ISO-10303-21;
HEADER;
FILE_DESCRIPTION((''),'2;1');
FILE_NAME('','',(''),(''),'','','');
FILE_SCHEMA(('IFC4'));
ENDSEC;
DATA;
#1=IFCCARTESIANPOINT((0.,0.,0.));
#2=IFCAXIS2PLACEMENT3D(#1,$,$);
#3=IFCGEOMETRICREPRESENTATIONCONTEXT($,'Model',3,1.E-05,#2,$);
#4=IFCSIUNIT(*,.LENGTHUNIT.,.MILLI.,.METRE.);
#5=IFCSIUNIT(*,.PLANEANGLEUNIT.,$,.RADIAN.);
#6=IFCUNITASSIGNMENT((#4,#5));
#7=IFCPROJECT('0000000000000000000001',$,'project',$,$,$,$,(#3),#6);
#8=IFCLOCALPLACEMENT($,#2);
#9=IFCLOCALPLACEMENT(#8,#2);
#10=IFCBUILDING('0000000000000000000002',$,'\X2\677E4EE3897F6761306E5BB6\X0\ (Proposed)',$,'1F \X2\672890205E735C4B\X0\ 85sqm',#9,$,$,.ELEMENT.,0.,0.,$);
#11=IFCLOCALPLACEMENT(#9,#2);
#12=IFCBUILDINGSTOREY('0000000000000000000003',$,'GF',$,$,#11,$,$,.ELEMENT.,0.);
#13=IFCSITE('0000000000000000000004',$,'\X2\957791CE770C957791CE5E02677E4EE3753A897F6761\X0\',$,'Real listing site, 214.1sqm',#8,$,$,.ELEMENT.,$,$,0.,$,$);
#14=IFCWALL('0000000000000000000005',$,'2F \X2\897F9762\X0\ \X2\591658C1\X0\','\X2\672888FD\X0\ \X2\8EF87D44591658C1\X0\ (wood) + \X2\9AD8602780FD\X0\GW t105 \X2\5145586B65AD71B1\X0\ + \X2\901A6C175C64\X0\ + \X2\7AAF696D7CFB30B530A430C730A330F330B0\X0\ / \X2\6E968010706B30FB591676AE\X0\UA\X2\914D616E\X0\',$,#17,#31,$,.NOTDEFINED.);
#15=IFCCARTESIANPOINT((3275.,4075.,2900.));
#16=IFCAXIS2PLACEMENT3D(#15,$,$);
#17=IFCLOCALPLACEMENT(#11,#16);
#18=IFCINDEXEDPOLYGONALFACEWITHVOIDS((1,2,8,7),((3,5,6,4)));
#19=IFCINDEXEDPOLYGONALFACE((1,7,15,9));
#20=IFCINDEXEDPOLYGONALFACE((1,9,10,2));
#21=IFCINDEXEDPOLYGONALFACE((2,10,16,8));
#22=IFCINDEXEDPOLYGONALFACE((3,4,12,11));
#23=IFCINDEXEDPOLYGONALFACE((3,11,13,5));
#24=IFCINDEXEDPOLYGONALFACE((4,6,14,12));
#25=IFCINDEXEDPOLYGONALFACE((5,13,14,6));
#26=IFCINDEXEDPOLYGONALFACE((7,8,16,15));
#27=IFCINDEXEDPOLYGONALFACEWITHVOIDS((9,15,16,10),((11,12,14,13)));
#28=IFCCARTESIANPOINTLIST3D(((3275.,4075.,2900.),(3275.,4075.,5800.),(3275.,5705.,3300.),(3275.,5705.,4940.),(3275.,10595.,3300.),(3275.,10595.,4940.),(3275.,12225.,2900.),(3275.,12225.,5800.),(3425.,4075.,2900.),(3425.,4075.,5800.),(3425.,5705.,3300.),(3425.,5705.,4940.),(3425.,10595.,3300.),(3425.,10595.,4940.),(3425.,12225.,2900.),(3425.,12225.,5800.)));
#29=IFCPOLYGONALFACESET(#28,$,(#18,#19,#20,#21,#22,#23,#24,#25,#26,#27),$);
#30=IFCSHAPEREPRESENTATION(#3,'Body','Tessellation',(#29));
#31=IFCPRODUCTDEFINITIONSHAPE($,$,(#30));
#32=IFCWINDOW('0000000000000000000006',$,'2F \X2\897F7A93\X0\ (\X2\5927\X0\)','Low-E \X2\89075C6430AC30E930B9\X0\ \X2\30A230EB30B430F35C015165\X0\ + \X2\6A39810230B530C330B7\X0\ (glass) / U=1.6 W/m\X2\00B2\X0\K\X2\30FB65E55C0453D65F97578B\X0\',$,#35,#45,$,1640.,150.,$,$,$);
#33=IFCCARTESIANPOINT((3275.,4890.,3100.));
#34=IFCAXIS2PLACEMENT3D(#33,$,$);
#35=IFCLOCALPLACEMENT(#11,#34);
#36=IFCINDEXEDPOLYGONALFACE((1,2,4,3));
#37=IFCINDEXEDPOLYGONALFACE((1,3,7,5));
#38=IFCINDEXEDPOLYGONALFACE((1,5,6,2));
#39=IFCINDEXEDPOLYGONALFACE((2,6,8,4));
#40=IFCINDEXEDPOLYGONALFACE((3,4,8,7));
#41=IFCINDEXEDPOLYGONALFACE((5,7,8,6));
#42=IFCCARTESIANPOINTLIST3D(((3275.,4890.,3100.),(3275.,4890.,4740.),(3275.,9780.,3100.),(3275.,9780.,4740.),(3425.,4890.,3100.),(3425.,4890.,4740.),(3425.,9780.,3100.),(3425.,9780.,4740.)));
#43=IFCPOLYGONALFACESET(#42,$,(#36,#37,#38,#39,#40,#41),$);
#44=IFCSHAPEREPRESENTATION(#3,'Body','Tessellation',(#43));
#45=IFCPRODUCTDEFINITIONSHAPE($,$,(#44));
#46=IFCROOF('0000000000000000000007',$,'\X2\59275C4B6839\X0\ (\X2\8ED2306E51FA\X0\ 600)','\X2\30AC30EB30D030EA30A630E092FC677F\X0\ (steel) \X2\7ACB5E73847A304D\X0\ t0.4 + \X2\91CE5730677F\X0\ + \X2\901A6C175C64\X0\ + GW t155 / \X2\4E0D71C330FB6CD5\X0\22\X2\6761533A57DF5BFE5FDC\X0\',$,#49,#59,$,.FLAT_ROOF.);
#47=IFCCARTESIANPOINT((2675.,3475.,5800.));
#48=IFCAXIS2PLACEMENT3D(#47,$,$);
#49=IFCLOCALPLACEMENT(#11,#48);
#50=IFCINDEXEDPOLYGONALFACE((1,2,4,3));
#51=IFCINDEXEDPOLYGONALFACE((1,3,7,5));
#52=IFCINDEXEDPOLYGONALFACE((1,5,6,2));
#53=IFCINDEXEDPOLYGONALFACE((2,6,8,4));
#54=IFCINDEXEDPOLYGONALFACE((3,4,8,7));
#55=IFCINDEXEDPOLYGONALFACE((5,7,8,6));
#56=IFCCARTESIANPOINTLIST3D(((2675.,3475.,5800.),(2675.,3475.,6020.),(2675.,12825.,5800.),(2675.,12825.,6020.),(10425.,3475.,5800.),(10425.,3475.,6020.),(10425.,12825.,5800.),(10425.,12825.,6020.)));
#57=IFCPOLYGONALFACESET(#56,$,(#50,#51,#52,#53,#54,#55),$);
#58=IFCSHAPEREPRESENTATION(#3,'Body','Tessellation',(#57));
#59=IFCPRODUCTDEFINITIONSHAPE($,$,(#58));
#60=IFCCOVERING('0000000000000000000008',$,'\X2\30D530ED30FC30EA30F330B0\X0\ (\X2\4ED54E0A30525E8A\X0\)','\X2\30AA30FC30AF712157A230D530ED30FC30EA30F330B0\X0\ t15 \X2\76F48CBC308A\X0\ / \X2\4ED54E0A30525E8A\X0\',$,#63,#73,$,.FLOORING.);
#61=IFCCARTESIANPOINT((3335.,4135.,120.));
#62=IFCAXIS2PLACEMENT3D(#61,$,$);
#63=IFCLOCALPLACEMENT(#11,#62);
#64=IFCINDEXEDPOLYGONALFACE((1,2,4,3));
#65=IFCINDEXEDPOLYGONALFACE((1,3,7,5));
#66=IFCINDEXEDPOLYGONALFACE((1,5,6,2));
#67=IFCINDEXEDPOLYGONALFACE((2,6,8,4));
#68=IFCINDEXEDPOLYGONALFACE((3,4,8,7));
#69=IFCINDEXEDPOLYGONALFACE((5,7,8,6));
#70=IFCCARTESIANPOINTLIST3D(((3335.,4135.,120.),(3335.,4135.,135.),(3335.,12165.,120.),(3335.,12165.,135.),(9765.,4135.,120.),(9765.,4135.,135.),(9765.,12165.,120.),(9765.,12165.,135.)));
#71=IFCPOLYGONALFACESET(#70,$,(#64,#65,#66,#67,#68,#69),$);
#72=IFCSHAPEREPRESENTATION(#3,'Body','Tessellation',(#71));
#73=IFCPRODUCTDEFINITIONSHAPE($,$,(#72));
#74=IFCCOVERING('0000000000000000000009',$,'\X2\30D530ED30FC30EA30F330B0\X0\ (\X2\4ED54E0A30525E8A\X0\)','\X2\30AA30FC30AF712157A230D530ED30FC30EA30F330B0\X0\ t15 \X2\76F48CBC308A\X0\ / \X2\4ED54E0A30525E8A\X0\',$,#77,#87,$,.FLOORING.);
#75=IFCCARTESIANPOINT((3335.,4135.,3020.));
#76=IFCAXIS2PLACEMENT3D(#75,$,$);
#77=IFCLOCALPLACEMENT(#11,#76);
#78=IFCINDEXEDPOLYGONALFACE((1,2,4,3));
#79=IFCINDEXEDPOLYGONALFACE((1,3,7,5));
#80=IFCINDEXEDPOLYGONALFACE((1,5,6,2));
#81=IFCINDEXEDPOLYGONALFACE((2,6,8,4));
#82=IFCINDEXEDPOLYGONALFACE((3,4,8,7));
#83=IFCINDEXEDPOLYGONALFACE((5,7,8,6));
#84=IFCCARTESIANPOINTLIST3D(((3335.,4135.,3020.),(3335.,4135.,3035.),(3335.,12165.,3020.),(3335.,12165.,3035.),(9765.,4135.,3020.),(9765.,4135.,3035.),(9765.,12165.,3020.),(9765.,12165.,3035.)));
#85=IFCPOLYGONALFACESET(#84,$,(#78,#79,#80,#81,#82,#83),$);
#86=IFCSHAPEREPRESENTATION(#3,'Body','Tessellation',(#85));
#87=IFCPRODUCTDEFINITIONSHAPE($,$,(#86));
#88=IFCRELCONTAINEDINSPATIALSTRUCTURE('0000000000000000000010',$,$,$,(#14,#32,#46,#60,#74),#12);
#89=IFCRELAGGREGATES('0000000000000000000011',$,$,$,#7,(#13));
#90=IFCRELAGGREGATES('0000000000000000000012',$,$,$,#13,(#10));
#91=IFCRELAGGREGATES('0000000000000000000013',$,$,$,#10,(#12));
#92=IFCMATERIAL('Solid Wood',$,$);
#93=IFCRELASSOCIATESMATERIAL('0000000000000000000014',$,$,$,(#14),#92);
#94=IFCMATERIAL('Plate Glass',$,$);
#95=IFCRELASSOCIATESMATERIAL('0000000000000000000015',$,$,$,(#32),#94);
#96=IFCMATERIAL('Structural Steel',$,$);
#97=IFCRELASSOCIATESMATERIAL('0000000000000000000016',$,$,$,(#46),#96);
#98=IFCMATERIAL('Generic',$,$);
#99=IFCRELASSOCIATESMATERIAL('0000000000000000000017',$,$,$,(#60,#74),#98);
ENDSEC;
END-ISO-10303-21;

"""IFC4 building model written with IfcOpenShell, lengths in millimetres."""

from ifc_helpers import new_model, si_unit, frame, frame_2d, origin, place, context, project, spatial, rectangle, extrude, material, element, fill, save


model = new_model("IFC4")

# Units and contexts
model_context = context("Model", 3, precision=1e-05, world=origin())
ifc_project = project(units=[si_unit("LENGTHUNIT", "METRE", prefix="MILLI"), si_unit("PLANEANGLEUNIT", "RADIAN")], contexts=[model_context])

# Site, building, storey
site_placement = place(None, origin())
site = spatial("IfcSite", under=ifc_project, at=site_placement, Name="長野県長野市松代町西条", ObjectType="Real listing site, 214.1sqm", CompositionType="ELEMENT", RefElevation=0.0)
building_placement = place(site_placement, origin())
building = spatial("IfcBuilding", under=site, at=building_placement, Name="松代西条の家 (Proposed)", ObjectType="1F 木造平屋 85sqm", CompositionType="ELEMENT", ElevationOfRefHeight=0.0, ElevationOfTerrain=0.0)
storey_placement = place(building_placement, origin())
storey = spatial("IfcBuildingStorey", under=building, at=storey_placement, Name="GF", CompositionType="ELEMENT", Elevation=0.0)

# Shared definitions
ifc_material_1 = material(Name="Solid Wood")
ifc_material_2 = material(Name="Generic")

# Shared definitions
ifc_material_3 = material(Name="Plate Glass")

# Wall, opening, window
wall_1_placement = place(storey_placement, frame((3275.0, 4075.0, 2900.0)))
wall_1 = element("IfcWall", 1, at=wall_1_placement, inside=storey, material=ifc_material_1, Name="2F 西面 外壁", Description="木製 軸組外壁 (wood) + 高性能GW t105 充填断熱 + 通気層 + 窯業系サイディング / 準耐火・外皮UA配慮", PredefinedType="NOTDEFINED", context=model_context, shape_type="SweptSolid", body=[
    extrude(rectangle(XDim=150.0, YDim=8150.0, at=frame_2d((75.0, 4075.0))), frame((3275.0, 4075.0, 2900.0)), (0.0, 0.0, 1.0), 2900.0),
])
opening_1_placement = place(storey_placement, frame((3275.0, 4890.0, 3100.0)))
opening_1 = element("IfcOpeningElement", 2, at=opening_1_placement, cuts=wall_1, PredefinedType="NOTDEFINED", context=model_context, shape_type="SweptSolid", body=[
    extrude(rectangle(XDim=150.0, YDim=4890.0, at=frame_2d((75.0, 2445.0))), frame((3275.0, 4890.0, 3100.0)), (0.0, 0.0, 1.0), 1640.0),
])
window_1_placement = place(storey_placement, frame((3275.0, 4890.0, 3100.0)))
window_1 = element("IfcWindow", 3, at=window_1_placement, inside=storey, material=ifc_material_3, Name="2F 西窓 (大)", Description="Low-E 複層ガラス アルゴン封入 + 樹脂サッシ (glass) / U=1.6 W/m²K・日射取得型", OverallHeight=1640.0, OverallWidth=150.0, context=model_context, shape_type="SweptSolid", body=[
    extrude(rectangle(XDim=150.0, YDim=4890.0, at=frame_2d((75.0, 2445.0))), frame((3275.0, 4890.0, 3100.0)), (0.0, 0.0, 1.0), 1640.0),
])
fill(opening_1, window_1)

# Roof
ifc_material_4 = material(Name="Structural Steel")
roof_placement = place(storey_placement, frame((2675.0, 3475.0, 5800.0)))
element("IfcRoof", 4, at=roof_placement, inside=storey, material=ifc_material_4, Name="大屋根 (軒の出 600)", Description="ガルバリウム鋼板 (steel) 立平葺き t0.4 + 野地板 + 通気層 + GW t155 / 不燃・法22条区域対応", PredefinedType="FLAT_ROOF", context=model_context, shape_type="SweptSolid", body=[
    extrude(rectangle(XDim=7750.0, YDim=9350.0, at=frame_2d((3875.0, 4675.0))), frame((2675.0, 3475.0, 5800.0)), (0.0, 0.0, 1.0), 220.0),
])

# Coverings
covering_1_placement = place(storey_placement, frame((3335.0, 4135.0, 120.0)))
element("IfcCovering", 5, at=covering_1_placement, inside=storey, material=ifc_material_2, Name="フローリング (仕上げ床)", Description="オーク無垢フローリング t15 直貼り / 仕上げ床", PredefinedType="FLOORING", context=model_context, shape_type="SweptSolid", body=[
    extrude(rectangle(XDim=6430.0, YDim=8030.0, at=frame_2d((3215.0, 4015.0))), frame((3335.0, 4135.0, 120.0)), (0.0, 0.0, 1.0), 15.0),
])
covering_2_placement = place(storey_placement, frame((3335.0, 4135.0, 3020.0)))
element("IfcCovering", 6, at=covering_2_placement, inside=storey, material=ifc_material_2, Name="フローリング (仕上げ床)", Description="オーク無垢フローリング t15 直貼り / 仕上げ床", PredefinedType="FLOORING", context=model_context, shape_type="SweptSolid", body=[
    extrude(rectangle(XDim=6430.0, YDim=8030.0, at=frame_2d((3215.0, 4015.0))), frame((3335.0, 4135.0, 3020.0)), (0.0, 0.0, 1.0), 15.0),
])

save(model, "model.ifc")
